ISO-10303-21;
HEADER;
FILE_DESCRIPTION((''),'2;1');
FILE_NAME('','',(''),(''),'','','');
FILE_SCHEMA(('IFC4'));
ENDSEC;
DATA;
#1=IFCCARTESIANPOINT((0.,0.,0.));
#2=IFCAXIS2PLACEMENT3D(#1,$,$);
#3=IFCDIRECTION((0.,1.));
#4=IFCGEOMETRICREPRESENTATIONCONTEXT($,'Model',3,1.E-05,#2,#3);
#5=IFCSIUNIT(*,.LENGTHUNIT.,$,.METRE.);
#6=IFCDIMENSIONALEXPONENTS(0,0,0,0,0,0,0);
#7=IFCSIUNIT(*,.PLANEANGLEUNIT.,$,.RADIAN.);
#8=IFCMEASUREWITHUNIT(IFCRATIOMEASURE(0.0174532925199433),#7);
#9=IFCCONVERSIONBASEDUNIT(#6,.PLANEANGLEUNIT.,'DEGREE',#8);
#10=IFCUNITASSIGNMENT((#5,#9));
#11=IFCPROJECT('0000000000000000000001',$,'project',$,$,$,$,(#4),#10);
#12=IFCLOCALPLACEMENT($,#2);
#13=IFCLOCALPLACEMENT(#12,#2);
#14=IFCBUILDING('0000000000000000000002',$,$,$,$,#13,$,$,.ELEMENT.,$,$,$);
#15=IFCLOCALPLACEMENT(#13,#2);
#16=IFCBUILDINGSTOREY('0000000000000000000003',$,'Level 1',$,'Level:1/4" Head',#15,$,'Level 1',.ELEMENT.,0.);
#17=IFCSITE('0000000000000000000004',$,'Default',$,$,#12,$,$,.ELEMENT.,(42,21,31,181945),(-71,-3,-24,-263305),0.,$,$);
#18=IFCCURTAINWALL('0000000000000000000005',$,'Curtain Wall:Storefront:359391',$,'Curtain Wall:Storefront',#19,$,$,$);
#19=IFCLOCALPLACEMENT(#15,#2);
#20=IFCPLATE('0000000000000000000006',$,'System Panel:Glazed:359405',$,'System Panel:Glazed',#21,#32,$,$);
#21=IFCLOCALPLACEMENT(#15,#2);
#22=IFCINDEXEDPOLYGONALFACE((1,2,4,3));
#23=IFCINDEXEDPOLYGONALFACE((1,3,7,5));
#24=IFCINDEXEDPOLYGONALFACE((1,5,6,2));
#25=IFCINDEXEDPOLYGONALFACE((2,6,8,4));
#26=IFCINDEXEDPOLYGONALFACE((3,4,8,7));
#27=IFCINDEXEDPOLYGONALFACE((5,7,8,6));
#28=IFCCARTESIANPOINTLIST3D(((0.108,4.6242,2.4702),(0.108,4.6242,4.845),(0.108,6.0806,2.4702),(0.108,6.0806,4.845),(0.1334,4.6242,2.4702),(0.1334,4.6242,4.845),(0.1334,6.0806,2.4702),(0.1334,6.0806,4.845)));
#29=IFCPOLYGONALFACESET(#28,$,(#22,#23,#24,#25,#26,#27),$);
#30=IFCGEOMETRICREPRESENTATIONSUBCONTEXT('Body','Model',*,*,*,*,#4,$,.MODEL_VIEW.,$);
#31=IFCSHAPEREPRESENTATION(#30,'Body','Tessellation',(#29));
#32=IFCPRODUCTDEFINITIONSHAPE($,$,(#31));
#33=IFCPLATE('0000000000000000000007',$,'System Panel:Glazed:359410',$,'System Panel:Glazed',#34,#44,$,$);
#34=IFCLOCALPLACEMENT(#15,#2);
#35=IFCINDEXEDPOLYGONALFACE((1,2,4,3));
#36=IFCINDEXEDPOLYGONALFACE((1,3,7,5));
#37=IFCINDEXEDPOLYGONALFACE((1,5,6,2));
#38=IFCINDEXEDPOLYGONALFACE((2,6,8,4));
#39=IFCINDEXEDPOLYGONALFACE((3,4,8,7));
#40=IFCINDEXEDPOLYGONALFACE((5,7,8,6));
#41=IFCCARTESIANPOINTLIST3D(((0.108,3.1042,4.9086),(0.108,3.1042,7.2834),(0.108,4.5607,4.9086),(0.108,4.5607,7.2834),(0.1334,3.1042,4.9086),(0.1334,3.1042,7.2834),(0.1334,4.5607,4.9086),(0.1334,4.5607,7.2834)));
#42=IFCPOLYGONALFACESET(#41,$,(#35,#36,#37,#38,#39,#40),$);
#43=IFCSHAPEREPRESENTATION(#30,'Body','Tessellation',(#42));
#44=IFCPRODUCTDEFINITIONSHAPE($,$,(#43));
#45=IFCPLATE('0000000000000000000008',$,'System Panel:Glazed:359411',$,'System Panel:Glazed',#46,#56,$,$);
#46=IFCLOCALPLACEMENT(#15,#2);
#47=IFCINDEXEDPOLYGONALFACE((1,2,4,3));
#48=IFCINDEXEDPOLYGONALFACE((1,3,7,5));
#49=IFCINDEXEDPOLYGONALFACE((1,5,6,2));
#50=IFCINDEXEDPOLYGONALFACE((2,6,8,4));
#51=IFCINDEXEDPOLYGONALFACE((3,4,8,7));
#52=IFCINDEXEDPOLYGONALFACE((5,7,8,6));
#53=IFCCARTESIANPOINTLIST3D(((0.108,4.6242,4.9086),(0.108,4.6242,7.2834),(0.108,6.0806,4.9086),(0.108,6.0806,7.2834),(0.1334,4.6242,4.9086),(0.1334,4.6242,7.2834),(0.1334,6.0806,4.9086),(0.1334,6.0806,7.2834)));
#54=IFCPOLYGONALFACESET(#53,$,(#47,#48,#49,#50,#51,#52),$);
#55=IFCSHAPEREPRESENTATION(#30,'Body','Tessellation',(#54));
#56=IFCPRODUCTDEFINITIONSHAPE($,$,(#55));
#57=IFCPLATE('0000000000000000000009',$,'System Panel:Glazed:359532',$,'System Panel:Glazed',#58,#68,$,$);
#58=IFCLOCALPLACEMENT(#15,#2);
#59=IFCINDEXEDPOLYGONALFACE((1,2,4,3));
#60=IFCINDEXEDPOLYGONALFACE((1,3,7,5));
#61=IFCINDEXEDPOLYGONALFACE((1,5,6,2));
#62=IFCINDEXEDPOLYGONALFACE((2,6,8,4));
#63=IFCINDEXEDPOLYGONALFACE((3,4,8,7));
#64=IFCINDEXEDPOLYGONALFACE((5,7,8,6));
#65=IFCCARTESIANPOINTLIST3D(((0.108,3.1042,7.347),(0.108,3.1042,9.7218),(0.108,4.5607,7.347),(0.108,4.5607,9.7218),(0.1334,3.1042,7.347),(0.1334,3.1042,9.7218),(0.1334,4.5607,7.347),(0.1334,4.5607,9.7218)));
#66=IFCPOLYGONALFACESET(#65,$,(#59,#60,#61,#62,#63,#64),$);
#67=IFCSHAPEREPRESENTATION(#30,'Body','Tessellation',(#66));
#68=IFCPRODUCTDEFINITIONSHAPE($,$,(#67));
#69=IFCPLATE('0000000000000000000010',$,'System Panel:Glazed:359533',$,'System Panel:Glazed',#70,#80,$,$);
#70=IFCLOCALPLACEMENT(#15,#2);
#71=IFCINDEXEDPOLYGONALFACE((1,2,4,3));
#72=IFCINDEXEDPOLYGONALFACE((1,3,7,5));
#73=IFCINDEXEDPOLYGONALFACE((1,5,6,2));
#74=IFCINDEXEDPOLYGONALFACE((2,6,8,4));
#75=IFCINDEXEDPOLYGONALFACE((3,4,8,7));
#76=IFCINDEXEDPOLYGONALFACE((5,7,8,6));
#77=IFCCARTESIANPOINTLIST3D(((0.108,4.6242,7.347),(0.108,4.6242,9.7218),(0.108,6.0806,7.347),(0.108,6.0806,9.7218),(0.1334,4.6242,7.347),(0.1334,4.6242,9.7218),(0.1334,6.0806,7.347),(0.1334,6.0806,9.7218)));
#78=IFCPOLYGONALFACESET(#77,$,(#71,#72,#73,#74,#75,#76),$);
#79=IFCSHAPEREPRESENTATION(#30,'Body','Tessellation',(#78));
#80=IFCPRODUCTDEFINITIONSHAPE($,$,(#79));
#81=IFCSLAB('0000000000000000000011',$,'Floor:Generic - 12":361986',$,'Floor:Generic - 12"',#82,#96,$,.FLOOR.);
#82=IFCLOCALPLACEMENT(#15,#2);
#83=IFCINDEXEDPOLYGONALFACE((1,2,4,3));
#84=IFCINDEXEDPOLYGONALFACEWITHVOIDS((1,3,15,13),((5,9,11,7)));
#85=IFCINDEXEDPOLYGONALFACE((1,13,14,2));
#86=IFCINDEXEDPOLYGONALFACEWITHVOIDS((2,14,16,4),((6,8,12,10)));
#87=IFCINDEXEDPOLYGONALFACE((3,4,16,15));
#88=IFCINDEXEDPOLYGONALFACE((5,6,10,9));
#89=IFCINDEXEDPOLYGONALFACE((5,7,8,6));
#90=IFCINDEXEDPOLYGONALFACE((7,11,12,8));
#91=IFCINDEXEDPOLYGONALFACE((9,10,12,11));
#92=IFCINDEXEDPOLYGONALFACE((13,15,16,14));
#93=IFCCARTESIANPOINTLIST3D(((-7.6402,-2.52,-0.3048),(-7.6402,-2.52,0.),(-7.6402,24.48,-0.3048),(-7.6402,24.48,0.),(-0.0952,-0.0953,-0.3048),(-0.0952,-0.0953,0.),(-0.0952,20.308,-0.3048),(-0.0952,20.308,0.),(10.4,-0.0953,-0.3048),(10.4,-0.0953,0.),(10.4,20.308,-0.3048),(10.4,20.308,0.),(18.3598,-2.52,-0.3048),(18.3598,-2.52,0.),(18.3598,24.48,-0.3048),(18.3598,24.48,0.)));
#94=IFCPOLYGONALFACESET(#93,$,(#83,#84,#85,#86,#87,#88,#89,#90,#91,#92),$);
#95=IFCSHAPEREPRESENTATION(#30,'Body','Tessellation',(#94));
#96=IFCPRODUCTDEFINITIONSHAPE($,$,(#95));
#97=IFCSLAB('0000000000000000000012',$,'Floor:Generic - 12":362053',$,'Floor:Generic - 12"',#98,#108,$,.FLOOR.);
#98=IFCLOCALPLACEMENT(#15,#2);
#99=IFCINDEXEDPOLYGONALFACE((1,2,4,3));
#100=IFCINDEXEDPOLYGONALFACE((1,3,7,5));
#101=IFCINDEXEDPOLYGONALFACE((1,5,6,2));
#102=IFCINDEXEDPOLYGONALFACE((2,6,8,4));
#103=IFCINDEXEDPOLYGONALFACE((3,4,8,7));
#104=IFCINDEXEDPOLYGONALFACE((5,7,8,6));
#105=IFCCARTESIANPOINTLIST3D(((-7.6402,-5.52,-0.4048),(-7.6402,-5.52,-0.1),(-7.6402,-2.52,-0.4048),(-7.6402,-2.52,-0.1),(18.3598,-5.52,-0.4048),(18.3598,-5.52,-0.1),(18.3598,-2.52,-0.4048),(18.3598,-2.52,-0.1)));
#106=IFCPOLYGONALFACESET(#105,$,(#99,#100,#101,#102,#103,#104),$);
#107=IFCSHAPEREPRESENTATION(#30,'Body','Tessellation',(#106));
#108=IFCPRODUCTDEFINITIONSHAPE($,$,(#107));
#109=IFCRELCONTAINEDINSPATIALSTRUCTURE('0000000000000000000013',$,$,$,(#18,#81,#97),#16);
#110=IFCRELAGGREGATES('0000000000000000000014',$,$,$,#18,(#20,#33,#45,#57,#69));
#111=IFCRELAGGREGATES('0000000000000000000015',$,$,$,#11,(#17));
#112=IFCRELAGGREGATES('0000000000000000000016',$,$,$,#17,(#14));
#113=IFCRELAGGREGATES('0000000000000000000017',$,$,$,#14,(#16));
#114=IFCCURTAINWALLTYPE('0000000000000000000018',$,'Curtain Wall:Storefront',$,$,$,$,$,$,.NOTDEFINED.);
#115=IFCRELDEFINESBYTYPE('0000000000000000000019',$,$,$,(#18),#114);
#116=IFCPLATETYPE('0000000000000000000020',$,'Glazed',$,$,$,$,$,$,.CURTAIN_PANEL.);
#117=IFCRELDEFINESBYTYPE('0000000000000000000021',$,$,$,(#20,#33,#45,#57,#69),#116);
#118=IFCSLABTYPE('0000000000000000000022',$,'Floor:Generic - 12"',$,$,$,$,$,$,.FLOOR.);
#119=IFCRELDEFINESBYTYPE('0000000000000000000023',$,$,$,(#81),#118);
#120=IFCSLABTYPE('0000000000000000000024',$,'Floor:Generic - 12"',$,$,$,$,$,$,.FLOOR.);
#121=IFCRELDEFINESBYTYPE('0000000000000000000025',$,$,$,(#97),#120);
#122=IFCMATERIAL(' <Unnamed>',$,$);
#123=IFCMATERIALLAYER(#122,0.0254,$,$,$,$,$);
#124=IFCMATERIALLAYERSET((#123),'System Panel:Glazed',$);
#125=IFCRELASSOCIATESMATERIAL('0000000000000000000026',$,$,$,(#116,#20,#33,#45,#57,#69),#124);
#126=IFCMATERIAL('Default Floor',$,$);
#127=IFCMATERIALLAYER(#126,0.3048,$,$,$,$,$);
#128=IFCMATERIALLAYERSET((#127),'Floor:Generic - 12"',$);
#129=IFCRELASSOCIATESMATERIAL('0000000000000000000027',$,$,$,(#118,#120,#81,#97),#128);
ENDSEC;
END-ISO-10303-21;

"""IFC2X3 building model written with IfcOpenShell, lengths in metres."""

from ifc_helpers import new_model, entity, si_unit, converted_unit, direction, frame, frame_2d, origin, origin_2d_with_axis, place, context, subcontext, project, spatial, rectangle, extrude, source, transform, mapped, material, layer, layer_set, layer_usage, type_object, type_shapes, element, aggregate, save


model = new_model("IFC2X3")

# Units and contexts
model_context = context("Model", 3, precision=1e-05, world=origin(), true_north=direction((0.0, 1.0)))
body_context = subcontext(model_context, "Body", "Model", "MODEL_VIEW")
ifc_project = project(units=[si_unit("LENGTHUNIT", "METRE"), converted_unit("PLANEANGLEUNIT", "DEGREE", entity("IfcRatioMeasure", 0.0174532925199433), si_unit("PLANEANGLEUNIT", "RADIAN"), dimensions=[0, 0, 0, 0, 0, 0, 0])], contexts=[model_context])

# Site, building, storey
site_placement = place(None, origin())
site = spatial("IfcSite", under=ifc_project, at=site_placement, Name="Default", CompositionType="ELEMENT", RefLatitude=(42, 21, 31, 181945), RefLongitude=(-71, -3, -24, -263305), RefElevation=0.0)
building_placement = place(site_placement, origin())
building = spatial("IfcBuilding", under=site, at=building_placement, CompositionType="ELEMENT")
storey_placement = place(building_placement, origin())
storey = spatial("IfcBuildingStorey", under=building, at=storey_placement, Name="Level 1", ObjectType="Level:1/4\" Head", LongName="Level 1", CompositionType="ELEMENT", Elevation=0.0)

# Curtain wall
curtain_wall_type = type_object("IfcCurtainWallType", Name="Curtain Wall:Storefront", PredefinedType="NOTDEFINED")
curtain_wall_placement = place(storey_placement, origin())
curtain_wall = element("IfcCurtainWall", 1, at=curtain_wall_placement, inside=storey, type_object=curtain_wall_type, Name="Curtain Wall:Storefront:359391", ObjectType="Curtain Wall:Storefront")

# Plates
ifc_material_1 = material(Name=" <Unnamed>")
ifc_layer_1 = layer(ifc_material_1, 0.0254)
ifc_layer_set_1 = layer_set([ifc_layer_1], Name="System Panel:Glazed")
plate_type_1 = type_object("IfcPlateType", Name="Glazed", PredefinedType="CURTAIN_PANEL", material=ifc_layer_set_1)
shared_shape_1 = source(origin(), body_context, "Body", "SweptSolid", [
    extrude(rectangle(XDim=0.0254, YDim=1.4565, at=frame_2d((0.0, 0.0), x_axis=(1.0, 0.0))), frame((0.7282, 0.0127, 0.0), z_axis=(0.0, 0.0, 1.0), x_axis=(0.0, 1.0, 0.0)), (0.0, 0.0, 1.0), 2.3749),
])
type_shapes(plate_type_1, [shared_shape_1])
ifc_layer_usage_1 = layer_usage(ifc_layer_set_1, "AXIS3", "POSITIVE", 0.1042)
plate_1_placement = place(curtain_wall_placement, frame((0.1334, 4.6242, 2.4701), z_axis=(0.0, 0.0, 1.0), x_axis=(0.0, 1.0, 0.0)))
plate_1 = element("IfcPlate", 2, at=plate_1_placement, type_object=plate_type_1, material=ifc_layer_usage_1, Name="System Panel:Glazed:359405", ObjectType="System Panel:Glazed", context=body_context, shape_type="MappedRepresentation", body=[
    mapped(shared_shape_1, transform((0.0, 0.0, 0.0), scale=1.0)),
])
ifc_layer_usage_2 = layer_usage(ifc_layer_set_1, "AXIS3", "POSITIVE", 0.1042)
plate_2_placement = place(curtain_wall_placement, frame((0.1334, 3.1042, 4.9085), z_axis=(0.0, 0.0, 1.0), x_axis=(0.0, 1.0, 0.0)))
plate_2 = element("IfcPlate", 3, at=plate_2_placement, type_object=plate_type_1, material=ifc_layer_usage_2, Name="System Panel:Glazed:359410", ObjectType="System Panel:Glazed", context=body_context, shape_type="MappedRepresentation", body=[
    mapped(shared_shape_1, transform((0.0, 0.0, 0.0), scale=1.0)),
])
ifc_layer_usage_3 = layer_usage(ifc_layer_set_1, "AXIS3", "POSITIVE", 0.1042)
plate_3_placement = place(curtain_wall_placement, frame((0.1334, 4.6242, 4.9085), z_axis=(0.0, 0.0, 1.0), x_axis=(0.0, 1.0, 0.0)))
plate_3 = element("IfcPlate", 4, at=plate_3_placement, type_object=plate_type_1, material=ifc_layer_usage_3, Name="System Panel:Glazed:359411", ObjectType="System Panel:Glazed", context=body_context, shape_type="MappedRepresentation", body=[
    mapped(shared_shape_1, transform((0.0, 0.0, 0.0), scale=1.0)),
])
ifc_layer_usage_4 = layer_usage(ifc_layer_set_1, "AXIS3", "POSITIVE", 0.1042)
plate_4_placement = place(curtain_wall_placement, frame((0.1334, 3.1042, 7.3469), z_axis=(0.0, 0.0, 1.0), x_axis=(0.0, 1.0, 0.0)))
plate_4 = element("IfcPlate", 5, at=plate_4_placement, type_object=plate_type_1, material=ifc_layer_usage_4, Name="System Panel:Glazed:359532", ObjectType="System Panel:Glazed", context=body_context, shape_type="MappedRepresentation", body=[
    mapped(shared_shape_1, transform((0.0, 0.0, 0.0), scale=1.0)),
])
ifc_layer_usage_5 = layer_usage(ifc_layer_set_1, "AXIS3", "POSITIVE", 0.1042)
plate_5_placement = place(curtain_wall_placement, frame((0.1334, 4.6242, 7.3469), z_axis=(0.0, 0.0, 1.0), x_axis=(0.0, 1.0, 0.0)))
plate_5 = element("IfcPlate", 6, at=plate_5_placement, type_object=plate_type_1, material=ifc_layer_usage_5, Name="System Panel:Glazed:359533", ObjectType="System Panel:Glazed", context=body_context, shape_type="MappedRepresentation", body=[
    mapped(shared_shape_1, transform((0.0, 0.0, 0.0), scale=1.0)),
])
aggregate(curtain_wall, [plate_1, plate_2, plate_3, plate_4, plate_5])

# Slab, opening
ifc_material_2 = material(Name="Default Floor")
ifc_layer_2 = layer(ifc_material_2, 0.3048)
ifc_layer_set_2 = layer_set([ifc_layer_2], Name="Floor:Generic - 12\"")
ifc_layer_usage_6 = layer_usage(ifc_layer_set_2, "AXIS3", "POSITIVE", 0.0)
slab_type_1 = type_object("IfcSlabType", Name="Floor:Generic - 12\"", PredefinedType="FLOOR", material=ifc_layer_set_2)
slab_1_placement = place(storey_placement, origin())
slab_1 = element("IfcSlab", 7, at=slab_1_placement, inside=storey, type_object=slab_type_1, material=ifc_layer_usage_6, Name="Floor:Generic - 12\":361986", ObjectType="Floor:Generic - 12\"", PredefinedType="FLOOR", context=body_context, shape_type="SweptSolid", body=[
    extrude(rectangle(XDim=27.0, YDim=26.0, at=frame_2d((0.0, 0.0), x_axis=(0.0, -1.0))), frame((5.3598, 10.98, 0.0), z_axis=(0.0, 0.0, -1.0), x_axis=(-1.0, 0.0, 0.0)), (0.0, 0.0, 1.0), 0.3048),
])
opening_1_placement = place(slab_1_placement, frame((5.1524, 10.1064, 0.0)))
element("IfcOpeningElement", 8, at=opening_1_placement, cuts=slab_1, ObjectType="Opening", context=body_context, shape_type="SweptSolid", body=[
    extrude(rectangle(XDim=20.4032, YDim=10.4953, at=origin_2d_with_axis()), frame((0.0, 0.0, 0.0), z_axis=(0.0, 0.0, -1.0), x_axis=(0.0, -1.0, 0.0)), (0.0, 0.0, 1.0), 0.3048),
])

# Slab
ifc_layer_usage_7 = layer_usage(ifc_layer_set_2, "AXIS3", "POSITIVE", 0.0)
slab_type_2 = type_object("IfcSlabType", Name="Floor:Generic - 12\"", PredefinedType="FLOOR", material=ifc_layer_set_2)
slab_2_placement = place(storey_placement, origin())
element("IfcSlab", 9, at=slab_2_placement, inside=storey, type_object=slab_type_2, material=ifc_layer_usage_7, Name="Floor:Generic - 12\":362053", ObjectType="Floor:Generic - 12\"", PredefinedType="FLOOR", context=body_context, shape_type="SweptSolid", body=[
    extrude(rectangle(XDim=3.0, YDim=26.0, at=origin_2d_with_axis()), frame((5.3598, -4.02, -0.1), z_axis=(0.0, 0.0, -1.0), x_axis=(0.0, 1.0, 0.0)), (0.0, 0.0, 1.0), 0.3048),
])

save(model, "model.ifc")
